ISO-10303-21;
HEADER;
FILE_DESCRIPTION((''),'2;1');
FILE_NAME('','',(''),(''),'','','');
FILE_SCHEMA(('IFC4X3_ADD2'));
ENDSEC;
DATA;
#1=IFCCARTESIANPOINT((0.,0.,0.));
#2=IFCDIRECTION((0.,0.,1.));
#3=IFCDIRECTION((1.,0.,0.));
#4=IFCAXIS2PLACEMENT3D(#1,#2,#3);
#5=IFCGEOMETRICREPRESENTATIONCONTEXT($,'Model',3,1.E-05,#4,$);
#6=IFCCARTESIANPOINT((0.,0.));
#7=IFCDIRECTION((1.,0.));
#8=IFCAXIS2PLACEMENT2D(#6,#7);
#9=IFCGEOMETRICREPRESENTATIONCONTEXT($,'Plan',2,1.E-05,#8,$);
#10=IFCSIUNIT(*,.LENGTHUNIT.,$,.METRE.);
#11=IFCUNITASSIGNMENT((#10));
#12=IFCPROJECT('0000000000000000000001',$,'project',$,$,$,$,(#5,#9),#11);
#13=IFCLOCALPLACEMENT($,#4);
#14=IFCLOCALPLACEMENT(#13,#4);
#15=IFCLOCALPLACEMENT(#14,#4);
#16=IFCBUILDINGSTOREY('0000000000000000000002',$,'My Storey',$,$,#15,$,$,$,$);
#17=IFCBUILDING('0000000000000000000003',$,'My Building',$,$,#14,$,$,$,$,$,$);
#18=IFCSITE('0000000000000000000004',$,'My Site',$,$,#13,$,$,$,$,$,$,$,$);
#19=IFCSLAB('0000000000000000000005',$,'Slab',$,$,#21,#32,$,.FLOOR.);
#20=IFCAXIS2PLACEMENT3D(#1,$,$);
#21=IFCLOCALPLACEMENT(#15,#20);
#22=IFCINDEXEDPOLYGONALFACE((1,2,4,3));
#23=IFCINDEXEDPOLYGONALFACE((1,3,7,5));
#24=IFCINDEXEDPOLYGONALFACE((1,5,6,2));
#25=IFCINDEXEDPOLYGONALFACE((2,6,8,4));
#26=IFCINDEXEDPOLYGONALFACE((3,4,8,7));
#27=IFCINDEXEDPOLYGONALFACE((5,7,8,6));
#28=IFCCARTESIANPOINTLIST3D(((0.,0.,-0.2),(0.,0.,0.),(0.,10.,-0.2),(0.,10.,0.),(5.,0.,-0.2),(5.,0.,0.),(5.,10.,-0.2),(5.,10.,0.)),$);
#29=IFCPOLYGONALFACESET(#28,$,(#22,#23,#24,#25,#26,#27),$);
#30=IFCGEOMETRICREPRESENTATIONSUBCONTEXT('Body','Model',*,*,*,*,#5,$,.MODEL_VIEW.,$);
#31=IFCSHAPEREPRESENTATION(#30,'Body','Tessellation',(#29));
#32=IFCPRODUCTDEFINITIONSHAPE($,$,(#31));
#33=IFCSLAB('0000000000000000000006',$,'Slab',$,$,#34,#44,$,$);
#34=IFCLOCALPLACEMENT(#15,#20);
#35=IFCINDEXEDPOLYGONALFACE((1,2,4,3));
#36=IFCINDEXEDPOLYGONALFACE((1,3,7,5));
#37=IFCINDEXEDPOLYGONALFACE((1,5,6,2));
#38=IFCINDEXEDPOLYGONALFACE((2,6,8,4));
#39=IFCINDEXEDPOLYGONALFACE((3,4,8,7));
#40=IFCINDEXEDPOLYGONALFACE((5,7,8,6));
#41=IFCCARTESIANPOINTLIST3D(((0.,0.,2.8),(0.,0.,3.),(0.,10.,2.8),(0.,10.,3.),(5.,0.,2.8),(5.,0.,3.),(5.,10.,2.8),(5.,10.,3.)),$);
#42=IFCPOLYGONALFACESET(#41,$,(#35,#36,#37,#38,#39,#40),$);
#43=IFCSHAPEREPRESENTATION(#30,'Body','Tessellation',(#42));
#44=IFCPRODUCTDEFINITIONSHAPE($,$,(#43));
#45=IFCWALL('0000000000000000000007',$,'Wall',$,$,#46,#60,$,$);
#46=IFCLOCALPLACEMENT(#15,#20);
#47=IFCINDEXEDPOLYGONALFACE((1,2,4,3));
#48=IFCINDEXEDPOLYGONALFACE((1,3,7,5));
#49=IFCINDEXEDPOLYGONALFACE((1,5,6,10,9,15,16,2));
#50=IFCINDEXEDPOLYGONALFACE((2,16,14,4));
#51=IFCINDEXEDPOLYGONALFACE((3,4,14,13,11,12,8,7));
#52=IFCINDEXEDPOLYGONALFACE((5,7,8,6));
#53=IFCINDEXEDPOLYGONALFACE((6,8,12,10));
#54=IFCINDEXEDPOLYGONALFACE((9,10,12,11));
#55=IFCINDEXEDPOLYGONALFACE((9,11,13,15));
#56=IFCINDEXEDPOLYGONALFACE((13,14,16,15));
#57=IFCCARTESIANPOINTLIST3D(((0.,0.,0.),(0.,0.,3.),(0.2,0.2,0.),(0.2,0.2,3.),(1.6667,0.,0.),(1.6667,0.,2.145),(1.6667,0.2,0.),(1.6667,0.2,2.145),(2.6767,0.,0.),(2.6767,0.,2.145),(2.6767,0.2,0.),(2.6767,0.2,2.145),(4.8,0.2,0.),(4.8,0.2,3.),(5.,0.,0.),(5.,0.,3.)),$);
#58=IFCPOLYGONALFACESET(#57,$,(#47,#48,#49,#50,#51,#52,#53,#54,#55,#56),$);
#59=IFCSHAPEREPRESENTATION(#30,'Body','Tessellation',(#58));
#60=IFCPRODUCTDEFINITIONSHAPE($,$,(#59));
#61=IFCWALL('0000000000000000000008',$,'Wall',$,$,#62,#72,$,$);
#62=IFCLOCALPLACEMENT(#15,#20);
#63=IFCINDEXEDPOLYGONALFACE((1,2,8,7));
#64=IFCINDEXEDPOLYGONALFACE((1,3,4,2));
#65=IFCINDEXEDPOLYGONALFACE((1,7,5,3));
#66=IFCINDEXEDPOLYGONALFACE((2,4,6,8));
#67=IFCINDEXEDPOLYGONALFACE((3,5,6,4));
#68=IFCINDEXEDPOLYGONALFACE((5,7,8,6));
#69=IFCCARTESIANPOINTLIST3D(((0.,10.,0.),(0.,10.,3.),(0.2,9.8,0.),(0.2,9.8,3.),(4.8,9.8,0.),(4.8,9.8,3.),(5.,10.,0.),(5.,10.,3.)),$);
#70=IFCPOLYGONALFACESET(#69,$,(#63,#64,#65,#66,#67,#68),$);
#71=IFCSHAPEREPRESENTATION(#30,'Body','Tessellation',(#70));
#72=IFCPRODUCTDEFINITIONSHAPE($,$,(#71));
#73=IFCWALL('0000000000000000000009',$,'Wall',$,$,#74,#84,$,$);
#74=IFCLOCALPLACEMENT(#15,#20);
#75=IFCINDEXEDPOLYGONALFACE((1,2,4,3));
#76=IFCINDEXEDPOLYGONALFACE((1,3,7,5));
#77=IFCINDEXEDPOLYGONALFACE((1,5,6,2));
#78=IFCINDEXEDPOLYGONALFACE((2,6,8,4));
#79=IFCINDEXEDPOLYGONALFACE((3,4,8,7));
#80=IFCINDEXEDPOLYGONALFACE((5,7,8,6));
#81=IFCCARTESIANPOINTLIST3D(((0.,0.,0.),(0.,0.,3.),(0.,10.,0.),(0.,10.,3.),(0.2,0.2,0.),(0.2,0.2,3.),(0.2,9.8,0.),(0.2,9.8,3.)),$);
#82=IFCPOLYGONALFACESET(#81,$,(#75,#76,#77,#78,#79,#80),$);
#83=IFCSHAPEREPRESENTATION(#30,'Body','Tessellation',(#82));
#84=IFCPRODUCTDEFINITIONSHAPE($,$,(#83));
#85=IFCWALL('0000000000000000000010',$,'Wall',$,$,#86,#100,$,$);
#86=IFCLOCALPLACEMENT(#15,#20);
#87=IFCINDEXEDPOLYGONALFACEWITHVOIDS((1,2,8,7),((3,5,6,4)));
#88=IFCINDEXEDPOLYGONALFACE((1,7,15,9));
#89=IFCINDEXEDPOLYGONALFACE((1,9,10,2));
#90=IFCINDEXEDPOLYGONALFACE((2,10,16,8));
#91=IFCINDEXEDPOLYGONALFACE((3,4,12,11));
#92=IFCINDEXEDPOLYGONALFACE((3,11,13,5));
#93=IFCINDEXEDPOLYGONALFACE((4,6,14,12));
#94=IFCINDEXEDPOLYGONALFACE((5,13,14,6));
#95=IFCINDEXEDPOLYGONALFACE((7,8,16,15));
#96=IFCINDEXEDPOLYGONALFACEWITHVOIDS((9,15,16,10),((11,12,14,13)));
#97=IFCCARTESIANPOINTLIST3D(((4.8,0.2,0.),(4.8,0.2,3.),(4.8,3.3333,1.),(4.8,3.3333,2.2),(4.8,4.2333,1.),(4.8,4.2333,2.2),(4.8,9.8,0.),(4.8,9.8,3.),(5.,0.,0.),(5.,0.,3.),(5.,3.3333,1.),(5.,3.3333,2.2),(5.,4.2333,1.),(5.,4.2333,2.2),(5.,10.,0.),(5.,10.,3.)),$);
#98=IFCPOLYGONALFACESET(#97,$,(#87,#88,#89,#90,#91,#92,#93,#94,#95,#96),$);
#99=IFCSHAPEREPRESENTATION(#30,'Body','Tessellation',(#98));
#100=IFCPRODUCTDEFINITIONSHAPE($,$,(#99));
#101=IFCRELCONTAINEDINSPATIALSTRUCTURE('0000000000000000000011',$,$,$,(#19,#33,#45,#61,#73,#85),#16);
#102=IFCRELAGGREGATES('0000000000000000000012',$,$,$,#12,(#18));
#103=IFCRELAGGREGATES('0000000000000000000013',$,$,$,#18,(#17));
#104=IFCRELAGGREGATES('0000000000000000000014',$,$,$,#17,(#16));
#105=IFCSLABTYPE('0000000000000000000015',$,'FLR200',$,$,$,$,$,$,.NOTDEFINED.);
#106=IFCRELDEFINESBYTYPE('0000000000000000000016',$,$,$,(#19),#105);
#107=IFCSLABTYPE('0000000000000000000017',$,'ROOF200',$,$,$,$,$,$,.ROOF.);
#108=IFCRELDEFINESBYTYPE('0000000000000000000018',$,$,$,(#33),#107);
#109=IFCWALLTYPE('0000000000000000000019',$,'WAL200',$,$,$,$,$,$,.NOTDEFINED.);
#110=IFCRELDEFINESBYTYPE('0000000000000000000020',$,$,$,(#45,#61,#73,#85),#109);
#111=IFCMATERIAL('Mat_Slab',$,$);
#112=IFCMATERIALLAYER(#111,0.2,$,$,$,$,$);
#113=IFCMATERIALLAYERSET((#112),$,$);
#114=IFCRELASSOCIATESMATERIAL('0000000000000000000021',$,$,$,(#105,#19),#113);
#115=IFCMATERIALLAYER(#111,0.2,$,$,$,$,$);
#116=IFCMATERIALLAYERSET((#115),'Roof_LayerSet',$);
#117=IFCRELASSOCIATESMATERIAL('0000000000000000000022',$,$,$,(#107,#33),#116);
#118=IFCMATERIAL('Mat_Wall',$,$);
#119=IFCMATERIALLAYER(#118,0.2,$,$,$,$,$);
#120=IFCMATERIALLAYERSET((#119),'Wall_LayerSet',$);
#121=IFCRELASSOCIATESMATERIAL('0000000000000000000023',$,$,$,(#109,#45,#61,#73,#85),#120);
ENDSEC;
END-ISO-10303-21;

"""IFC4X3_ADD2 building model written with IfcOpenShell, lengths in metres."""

from ifc_helpers import new_model, si_unit, frame, origin, origin_with_axes, origin_2d_with_axis, place, context, subcontext, project, spatial, polyline, line, indexed_curve, outline, extrude, source, transform, mapped, material, layer, layer_set, layer_usage, type_object, element, save


model = new_model("IFC4X3_ADD2")

# Units and contexts
model_context = context("Model", 3, precision=1e-05, world=origin_with_axes())
plan_context = context("Plan", 2, precision=1e-05, world=origin_2d_with_axis())
body_context = subcontext(model_context, "Body", "Model", "MODEL_VIEW")
ifc_project = project(units=[si_unit("LENGTHUNIT", "METRE")], contexts=[model_context, plan_context])

# Site, building, storey
site_placement = place(None, origin_with_axes())
site = spatial("IfcSite", under=ifc_project, at=site_placement, Name="My Site")
building_placement = place(site_placement, origin_with_axes())
building = spatial("IfcBuilding", under=site, at=building_placement, Name="My Building")
storey_placement = place(building_placement, origin_with_axes())
storey = spatial("IfcBuildingStorey", under=building, at=storey_placement, Name="My Storey")

# Slabs
ifc_material_1 = material(Name="Mat_Slab")
ifc_layer_1 = layer(ifc_material_1, 0.2)
ifc_layer_set_1 = layer_set([ifc_layer_1])
ifc_layer_usage_1 = layer_usage(ifc_layer_set_1, "AXIS3", "POSITIVE", 0.0)
slab_type_1 = type_object("IfcSlabType", Name="FLR200", PredefinedType="NOTDEFINED", material=ifc_layer_set_1)
slab_1_placement = place(storey_placement, frame((2.5, 5.0, -0.2), z_axis=(0.0, 0.0, 1.0), x_axis=(1.0, 0.0, 0.0)))
element("IfcSlab", 1, at=slab_1_placement, inside=storey, type_object=slab_type_1, material=ifc_layer_usage_1, Name="Slab", PredefinedType="FLOOR", context=body_context, shape_type="SweptSolid", body=[
    extrude(outline(polyline([(2.5, -5.0), (2.5, 5.0), (-2.5, 5.0), (-2.5, -5.0), (2.5, -5.0)])), origin(), (0.0, 0.0, 1.0), 0.2),
])
ifc_layer_2 = layer(ifc_material_1, 0.2)
ifc_layer_set_2 = layer_set([ifc_layer_2], Name="Roof_LayerSet")
ifc_layer_usage_2 = layer_usage(ifc_layer_set_2, "AXIS3", "POSITIVE", 0.0)
slab_type_2 = type_object("IfcSlabType", Name="ROOF200", PredefinedType="ROOF", material=ifc_layer_set_2)
slab_2_placement = place(storey_placement, frame((2.5, 5.0, 2.8), z_axis=(0.0, 0.0, 1.0), x_axis=(1.0, 0.0, 0.0)))
element("IfcSlab", 2, at=slab_2_placement, inside=storey, type_object=slab_type_2, material=ifc_layer_usage_2, Name="Slab", context=body_context, shape_type="SweptSolid", body=[
    extrude(outline(polyline([(-2.5, -5.0), (2.5, -5.0), (2.5, 5.0), (-2.5, 5.0), (-2.5, -5.0)])), origin(), (0.0, 0.0, 1.0), 0.2),
])

# Wall, opening
ifc_material_2 = material(Name="Mat_Wall")
ifc_layer_3 = layer(ifc_material_2, 0.2)
ifc_layer_set_3 = layer_set([ifc_layer_3], Name="Wall_LayerSet")
ifc_layer_usage_3 = layer_usage(ifc_layer_set_3, "AXIS2", "POSITIVE", -0.2)
wall_type = type_object("IfcWallType", Name="WAL200", PredefinedType="NOTDEFINED", material=ifc_layer_set_3)
wall_1_placement = place(storey_placement, frame((5.0, 0.0, 0.0), z_axis=(0.0, 0.0, 1.0), x_axis=(-1.0, 0.0, 0.0)))
wall_1 = element("IfcWall", 3, at=wall_1_placement, inside=storey, type_object=wall_type, material=ifc_layer_usage_3, Name="Wall", context=body_context, shape_type="SweptSolid", body=[
    extrude(outline(indexed_curve([(0.2, -0.2), (0.0, 0.0), (5.0, 0.0), (4.8, -0.2)], segments=[line(1, 2, 3, 4, 1)])), origin_with_axes(), (0.0, 0.0, 1.0), 3.0),
])
shared_shape_1 = source(origin_with_axes(), body_context, "Body", "SweptSolid", [
    extrude(outline(indexed_curve([(0.0, 0.0), (1.01, 0.0), (1.01, 2.145), (0.0, 2.145)], segments=[line(1, 2, 3, 4, 1)])), frame((0.0, -0.6, 0.0), z_axis=(0.0, -1.0, 0.0), x_axis=(1.0, 0.0, 0.0)), (0.0, 0.0, -1.0), 1.2),
])
opening_1_placement = place(wall_1_placement, frame((3.3333, 0.0, 0.0), z_axis=(0.0, 0.0, 1.0), x_axis=(-1.0, 0.0, 0.0)))
element("IfcOpeningElement", 4, at=opening_1_placement, cuts=wall_1, PredefinedType="OPENING", context=body_context, shape_type="MappedRepresentation", body=[
    mapped(shared_shape_1, transform((0.0, 0.0, 0.0), x_axis=(1.0, 0.0, 0.0), y_axis=(0.0, 1.0, 0.0), z_axis=(0.0, 0.0, 1.0), scale=1.0)),
])

# Walls
ifc_layer_usage_4 = layer_usage(ifc_layer_set_3, "AXIS2", "POSITIVE", -0.2)
wall_2_placement = place(storey_placement, frame((0.0, 10.0, 0.0), z_axis=(0.0, 0.0, 1.0), x_axis=(1.0, 0.0, 0.0)))
element("IfcWall", 5, at=wall_2_placement, inside=storey, type_object=wall_type, material=ifc_layer_usage_4, Name="Wall", context=body_context, shape_type="SweptSolid", body=[
    extrude(outline(indexed_curve([(0.2, -0.2), (0.0, 0.0), (5.0, 0.0), (4.8, -0.2)], segments=[line(1, 2, 3, 4, 1)])), origin_with_axes(), (0.0, 0.0, 1.0), 3.0),
])
ifc_layer_usage_5 = layer_usage(ifc_layer_set_3, "AXIS2", "POSITIVE", -0.2)
wall_3_placement = place(storey_placement, frame((0.0, 0.0, 0.0), z_axis=(0.0, 0.0, 1.0), x_axis=(0.0, 1.0, 0.0)))
element("IfcWall", 6, at=wall_3_placement, inside=storey, type_object=wall_type, material=ifc_layer_usage_5, Name="Wall", context=body_context, shape_type="SweptSolid", body=[
    extrude(outline(indexed_curve([(0.2, -0.2), (0.0, 0.0), (10.0, 0.0), (9.8, -0.2)], segments=[line(1, 2, 3, 4, 1)])), origin_with_axes(), (0.0, 0.0, 1.0), 3.0),
])

# Wall, opening
ifc_layer_usage_6 = layer_usage(ifc_layer_set_3, "AXIS2", "POSITIVE", -0.2)
wall_4_placement = place(storey_placement, frame((5.0, 10.0, 0.0), z_axis=(0.0, 0.0, 1.0), x_axis=(0.0, -1.0, 0.0)))
wall_4 = element("IfcWall", 7, at=wall_4_placement, inside=storey, type_object=wall_type, material=ifc_layer_usage_6, Name="Wall", context=body_context, shape_type="SweptSolid", body=[
    extrude(outline(indexed_curve([(0.2, -0.2), (0.0, 0.0), (10.0, 0.0), (9.8, -0.2)], segments=[line(1, 2, 3, 4, 1)])), origin_with_axes(), (0.0, 0.0, 1.0), 3.0),
])
shared_shape_2 = source(origin_with_axes(), body_context, "Body", "SweptSolid", [
    extrude(outline(indexed_curve([(0.0, 0.0), (0.9, 0.0), (0.9, 1.2), (0.0, 1.2)], segments=[line(1, 2, 3, 4, 1)])), frame((0.0, -0.6, 0.0), z_axis=(0.0, -1.0, 0.0), x_axis=(1.0, 0.0, 0.0)), (0.0, 0.0, -1.0), 1.2),
])
opening_2_placement = place(wall_4_placement, frame((6.6667, 0.0, 1.0), z_axis=(0.0, 0.0, 1.0), x_axis=(-1.0, 0.0, 0.0)))
element("IfcOpeningElement", 8, at=opening_2_placement, cuts=wall_4, PredefinedType="OPENING", context=body_context, shape_type="MappedRepresentation", body=[
    mapped(shared_shape_2, transform((0.0, 0.0, 0.0), x_axis=(1.0, 0.0, 0.0), y_axis=(0.0, 1.0, 0.0), z_axis=(0.0, 0.0, 1.0), scale=1.0)),
])

save(model, "model.ifc")
